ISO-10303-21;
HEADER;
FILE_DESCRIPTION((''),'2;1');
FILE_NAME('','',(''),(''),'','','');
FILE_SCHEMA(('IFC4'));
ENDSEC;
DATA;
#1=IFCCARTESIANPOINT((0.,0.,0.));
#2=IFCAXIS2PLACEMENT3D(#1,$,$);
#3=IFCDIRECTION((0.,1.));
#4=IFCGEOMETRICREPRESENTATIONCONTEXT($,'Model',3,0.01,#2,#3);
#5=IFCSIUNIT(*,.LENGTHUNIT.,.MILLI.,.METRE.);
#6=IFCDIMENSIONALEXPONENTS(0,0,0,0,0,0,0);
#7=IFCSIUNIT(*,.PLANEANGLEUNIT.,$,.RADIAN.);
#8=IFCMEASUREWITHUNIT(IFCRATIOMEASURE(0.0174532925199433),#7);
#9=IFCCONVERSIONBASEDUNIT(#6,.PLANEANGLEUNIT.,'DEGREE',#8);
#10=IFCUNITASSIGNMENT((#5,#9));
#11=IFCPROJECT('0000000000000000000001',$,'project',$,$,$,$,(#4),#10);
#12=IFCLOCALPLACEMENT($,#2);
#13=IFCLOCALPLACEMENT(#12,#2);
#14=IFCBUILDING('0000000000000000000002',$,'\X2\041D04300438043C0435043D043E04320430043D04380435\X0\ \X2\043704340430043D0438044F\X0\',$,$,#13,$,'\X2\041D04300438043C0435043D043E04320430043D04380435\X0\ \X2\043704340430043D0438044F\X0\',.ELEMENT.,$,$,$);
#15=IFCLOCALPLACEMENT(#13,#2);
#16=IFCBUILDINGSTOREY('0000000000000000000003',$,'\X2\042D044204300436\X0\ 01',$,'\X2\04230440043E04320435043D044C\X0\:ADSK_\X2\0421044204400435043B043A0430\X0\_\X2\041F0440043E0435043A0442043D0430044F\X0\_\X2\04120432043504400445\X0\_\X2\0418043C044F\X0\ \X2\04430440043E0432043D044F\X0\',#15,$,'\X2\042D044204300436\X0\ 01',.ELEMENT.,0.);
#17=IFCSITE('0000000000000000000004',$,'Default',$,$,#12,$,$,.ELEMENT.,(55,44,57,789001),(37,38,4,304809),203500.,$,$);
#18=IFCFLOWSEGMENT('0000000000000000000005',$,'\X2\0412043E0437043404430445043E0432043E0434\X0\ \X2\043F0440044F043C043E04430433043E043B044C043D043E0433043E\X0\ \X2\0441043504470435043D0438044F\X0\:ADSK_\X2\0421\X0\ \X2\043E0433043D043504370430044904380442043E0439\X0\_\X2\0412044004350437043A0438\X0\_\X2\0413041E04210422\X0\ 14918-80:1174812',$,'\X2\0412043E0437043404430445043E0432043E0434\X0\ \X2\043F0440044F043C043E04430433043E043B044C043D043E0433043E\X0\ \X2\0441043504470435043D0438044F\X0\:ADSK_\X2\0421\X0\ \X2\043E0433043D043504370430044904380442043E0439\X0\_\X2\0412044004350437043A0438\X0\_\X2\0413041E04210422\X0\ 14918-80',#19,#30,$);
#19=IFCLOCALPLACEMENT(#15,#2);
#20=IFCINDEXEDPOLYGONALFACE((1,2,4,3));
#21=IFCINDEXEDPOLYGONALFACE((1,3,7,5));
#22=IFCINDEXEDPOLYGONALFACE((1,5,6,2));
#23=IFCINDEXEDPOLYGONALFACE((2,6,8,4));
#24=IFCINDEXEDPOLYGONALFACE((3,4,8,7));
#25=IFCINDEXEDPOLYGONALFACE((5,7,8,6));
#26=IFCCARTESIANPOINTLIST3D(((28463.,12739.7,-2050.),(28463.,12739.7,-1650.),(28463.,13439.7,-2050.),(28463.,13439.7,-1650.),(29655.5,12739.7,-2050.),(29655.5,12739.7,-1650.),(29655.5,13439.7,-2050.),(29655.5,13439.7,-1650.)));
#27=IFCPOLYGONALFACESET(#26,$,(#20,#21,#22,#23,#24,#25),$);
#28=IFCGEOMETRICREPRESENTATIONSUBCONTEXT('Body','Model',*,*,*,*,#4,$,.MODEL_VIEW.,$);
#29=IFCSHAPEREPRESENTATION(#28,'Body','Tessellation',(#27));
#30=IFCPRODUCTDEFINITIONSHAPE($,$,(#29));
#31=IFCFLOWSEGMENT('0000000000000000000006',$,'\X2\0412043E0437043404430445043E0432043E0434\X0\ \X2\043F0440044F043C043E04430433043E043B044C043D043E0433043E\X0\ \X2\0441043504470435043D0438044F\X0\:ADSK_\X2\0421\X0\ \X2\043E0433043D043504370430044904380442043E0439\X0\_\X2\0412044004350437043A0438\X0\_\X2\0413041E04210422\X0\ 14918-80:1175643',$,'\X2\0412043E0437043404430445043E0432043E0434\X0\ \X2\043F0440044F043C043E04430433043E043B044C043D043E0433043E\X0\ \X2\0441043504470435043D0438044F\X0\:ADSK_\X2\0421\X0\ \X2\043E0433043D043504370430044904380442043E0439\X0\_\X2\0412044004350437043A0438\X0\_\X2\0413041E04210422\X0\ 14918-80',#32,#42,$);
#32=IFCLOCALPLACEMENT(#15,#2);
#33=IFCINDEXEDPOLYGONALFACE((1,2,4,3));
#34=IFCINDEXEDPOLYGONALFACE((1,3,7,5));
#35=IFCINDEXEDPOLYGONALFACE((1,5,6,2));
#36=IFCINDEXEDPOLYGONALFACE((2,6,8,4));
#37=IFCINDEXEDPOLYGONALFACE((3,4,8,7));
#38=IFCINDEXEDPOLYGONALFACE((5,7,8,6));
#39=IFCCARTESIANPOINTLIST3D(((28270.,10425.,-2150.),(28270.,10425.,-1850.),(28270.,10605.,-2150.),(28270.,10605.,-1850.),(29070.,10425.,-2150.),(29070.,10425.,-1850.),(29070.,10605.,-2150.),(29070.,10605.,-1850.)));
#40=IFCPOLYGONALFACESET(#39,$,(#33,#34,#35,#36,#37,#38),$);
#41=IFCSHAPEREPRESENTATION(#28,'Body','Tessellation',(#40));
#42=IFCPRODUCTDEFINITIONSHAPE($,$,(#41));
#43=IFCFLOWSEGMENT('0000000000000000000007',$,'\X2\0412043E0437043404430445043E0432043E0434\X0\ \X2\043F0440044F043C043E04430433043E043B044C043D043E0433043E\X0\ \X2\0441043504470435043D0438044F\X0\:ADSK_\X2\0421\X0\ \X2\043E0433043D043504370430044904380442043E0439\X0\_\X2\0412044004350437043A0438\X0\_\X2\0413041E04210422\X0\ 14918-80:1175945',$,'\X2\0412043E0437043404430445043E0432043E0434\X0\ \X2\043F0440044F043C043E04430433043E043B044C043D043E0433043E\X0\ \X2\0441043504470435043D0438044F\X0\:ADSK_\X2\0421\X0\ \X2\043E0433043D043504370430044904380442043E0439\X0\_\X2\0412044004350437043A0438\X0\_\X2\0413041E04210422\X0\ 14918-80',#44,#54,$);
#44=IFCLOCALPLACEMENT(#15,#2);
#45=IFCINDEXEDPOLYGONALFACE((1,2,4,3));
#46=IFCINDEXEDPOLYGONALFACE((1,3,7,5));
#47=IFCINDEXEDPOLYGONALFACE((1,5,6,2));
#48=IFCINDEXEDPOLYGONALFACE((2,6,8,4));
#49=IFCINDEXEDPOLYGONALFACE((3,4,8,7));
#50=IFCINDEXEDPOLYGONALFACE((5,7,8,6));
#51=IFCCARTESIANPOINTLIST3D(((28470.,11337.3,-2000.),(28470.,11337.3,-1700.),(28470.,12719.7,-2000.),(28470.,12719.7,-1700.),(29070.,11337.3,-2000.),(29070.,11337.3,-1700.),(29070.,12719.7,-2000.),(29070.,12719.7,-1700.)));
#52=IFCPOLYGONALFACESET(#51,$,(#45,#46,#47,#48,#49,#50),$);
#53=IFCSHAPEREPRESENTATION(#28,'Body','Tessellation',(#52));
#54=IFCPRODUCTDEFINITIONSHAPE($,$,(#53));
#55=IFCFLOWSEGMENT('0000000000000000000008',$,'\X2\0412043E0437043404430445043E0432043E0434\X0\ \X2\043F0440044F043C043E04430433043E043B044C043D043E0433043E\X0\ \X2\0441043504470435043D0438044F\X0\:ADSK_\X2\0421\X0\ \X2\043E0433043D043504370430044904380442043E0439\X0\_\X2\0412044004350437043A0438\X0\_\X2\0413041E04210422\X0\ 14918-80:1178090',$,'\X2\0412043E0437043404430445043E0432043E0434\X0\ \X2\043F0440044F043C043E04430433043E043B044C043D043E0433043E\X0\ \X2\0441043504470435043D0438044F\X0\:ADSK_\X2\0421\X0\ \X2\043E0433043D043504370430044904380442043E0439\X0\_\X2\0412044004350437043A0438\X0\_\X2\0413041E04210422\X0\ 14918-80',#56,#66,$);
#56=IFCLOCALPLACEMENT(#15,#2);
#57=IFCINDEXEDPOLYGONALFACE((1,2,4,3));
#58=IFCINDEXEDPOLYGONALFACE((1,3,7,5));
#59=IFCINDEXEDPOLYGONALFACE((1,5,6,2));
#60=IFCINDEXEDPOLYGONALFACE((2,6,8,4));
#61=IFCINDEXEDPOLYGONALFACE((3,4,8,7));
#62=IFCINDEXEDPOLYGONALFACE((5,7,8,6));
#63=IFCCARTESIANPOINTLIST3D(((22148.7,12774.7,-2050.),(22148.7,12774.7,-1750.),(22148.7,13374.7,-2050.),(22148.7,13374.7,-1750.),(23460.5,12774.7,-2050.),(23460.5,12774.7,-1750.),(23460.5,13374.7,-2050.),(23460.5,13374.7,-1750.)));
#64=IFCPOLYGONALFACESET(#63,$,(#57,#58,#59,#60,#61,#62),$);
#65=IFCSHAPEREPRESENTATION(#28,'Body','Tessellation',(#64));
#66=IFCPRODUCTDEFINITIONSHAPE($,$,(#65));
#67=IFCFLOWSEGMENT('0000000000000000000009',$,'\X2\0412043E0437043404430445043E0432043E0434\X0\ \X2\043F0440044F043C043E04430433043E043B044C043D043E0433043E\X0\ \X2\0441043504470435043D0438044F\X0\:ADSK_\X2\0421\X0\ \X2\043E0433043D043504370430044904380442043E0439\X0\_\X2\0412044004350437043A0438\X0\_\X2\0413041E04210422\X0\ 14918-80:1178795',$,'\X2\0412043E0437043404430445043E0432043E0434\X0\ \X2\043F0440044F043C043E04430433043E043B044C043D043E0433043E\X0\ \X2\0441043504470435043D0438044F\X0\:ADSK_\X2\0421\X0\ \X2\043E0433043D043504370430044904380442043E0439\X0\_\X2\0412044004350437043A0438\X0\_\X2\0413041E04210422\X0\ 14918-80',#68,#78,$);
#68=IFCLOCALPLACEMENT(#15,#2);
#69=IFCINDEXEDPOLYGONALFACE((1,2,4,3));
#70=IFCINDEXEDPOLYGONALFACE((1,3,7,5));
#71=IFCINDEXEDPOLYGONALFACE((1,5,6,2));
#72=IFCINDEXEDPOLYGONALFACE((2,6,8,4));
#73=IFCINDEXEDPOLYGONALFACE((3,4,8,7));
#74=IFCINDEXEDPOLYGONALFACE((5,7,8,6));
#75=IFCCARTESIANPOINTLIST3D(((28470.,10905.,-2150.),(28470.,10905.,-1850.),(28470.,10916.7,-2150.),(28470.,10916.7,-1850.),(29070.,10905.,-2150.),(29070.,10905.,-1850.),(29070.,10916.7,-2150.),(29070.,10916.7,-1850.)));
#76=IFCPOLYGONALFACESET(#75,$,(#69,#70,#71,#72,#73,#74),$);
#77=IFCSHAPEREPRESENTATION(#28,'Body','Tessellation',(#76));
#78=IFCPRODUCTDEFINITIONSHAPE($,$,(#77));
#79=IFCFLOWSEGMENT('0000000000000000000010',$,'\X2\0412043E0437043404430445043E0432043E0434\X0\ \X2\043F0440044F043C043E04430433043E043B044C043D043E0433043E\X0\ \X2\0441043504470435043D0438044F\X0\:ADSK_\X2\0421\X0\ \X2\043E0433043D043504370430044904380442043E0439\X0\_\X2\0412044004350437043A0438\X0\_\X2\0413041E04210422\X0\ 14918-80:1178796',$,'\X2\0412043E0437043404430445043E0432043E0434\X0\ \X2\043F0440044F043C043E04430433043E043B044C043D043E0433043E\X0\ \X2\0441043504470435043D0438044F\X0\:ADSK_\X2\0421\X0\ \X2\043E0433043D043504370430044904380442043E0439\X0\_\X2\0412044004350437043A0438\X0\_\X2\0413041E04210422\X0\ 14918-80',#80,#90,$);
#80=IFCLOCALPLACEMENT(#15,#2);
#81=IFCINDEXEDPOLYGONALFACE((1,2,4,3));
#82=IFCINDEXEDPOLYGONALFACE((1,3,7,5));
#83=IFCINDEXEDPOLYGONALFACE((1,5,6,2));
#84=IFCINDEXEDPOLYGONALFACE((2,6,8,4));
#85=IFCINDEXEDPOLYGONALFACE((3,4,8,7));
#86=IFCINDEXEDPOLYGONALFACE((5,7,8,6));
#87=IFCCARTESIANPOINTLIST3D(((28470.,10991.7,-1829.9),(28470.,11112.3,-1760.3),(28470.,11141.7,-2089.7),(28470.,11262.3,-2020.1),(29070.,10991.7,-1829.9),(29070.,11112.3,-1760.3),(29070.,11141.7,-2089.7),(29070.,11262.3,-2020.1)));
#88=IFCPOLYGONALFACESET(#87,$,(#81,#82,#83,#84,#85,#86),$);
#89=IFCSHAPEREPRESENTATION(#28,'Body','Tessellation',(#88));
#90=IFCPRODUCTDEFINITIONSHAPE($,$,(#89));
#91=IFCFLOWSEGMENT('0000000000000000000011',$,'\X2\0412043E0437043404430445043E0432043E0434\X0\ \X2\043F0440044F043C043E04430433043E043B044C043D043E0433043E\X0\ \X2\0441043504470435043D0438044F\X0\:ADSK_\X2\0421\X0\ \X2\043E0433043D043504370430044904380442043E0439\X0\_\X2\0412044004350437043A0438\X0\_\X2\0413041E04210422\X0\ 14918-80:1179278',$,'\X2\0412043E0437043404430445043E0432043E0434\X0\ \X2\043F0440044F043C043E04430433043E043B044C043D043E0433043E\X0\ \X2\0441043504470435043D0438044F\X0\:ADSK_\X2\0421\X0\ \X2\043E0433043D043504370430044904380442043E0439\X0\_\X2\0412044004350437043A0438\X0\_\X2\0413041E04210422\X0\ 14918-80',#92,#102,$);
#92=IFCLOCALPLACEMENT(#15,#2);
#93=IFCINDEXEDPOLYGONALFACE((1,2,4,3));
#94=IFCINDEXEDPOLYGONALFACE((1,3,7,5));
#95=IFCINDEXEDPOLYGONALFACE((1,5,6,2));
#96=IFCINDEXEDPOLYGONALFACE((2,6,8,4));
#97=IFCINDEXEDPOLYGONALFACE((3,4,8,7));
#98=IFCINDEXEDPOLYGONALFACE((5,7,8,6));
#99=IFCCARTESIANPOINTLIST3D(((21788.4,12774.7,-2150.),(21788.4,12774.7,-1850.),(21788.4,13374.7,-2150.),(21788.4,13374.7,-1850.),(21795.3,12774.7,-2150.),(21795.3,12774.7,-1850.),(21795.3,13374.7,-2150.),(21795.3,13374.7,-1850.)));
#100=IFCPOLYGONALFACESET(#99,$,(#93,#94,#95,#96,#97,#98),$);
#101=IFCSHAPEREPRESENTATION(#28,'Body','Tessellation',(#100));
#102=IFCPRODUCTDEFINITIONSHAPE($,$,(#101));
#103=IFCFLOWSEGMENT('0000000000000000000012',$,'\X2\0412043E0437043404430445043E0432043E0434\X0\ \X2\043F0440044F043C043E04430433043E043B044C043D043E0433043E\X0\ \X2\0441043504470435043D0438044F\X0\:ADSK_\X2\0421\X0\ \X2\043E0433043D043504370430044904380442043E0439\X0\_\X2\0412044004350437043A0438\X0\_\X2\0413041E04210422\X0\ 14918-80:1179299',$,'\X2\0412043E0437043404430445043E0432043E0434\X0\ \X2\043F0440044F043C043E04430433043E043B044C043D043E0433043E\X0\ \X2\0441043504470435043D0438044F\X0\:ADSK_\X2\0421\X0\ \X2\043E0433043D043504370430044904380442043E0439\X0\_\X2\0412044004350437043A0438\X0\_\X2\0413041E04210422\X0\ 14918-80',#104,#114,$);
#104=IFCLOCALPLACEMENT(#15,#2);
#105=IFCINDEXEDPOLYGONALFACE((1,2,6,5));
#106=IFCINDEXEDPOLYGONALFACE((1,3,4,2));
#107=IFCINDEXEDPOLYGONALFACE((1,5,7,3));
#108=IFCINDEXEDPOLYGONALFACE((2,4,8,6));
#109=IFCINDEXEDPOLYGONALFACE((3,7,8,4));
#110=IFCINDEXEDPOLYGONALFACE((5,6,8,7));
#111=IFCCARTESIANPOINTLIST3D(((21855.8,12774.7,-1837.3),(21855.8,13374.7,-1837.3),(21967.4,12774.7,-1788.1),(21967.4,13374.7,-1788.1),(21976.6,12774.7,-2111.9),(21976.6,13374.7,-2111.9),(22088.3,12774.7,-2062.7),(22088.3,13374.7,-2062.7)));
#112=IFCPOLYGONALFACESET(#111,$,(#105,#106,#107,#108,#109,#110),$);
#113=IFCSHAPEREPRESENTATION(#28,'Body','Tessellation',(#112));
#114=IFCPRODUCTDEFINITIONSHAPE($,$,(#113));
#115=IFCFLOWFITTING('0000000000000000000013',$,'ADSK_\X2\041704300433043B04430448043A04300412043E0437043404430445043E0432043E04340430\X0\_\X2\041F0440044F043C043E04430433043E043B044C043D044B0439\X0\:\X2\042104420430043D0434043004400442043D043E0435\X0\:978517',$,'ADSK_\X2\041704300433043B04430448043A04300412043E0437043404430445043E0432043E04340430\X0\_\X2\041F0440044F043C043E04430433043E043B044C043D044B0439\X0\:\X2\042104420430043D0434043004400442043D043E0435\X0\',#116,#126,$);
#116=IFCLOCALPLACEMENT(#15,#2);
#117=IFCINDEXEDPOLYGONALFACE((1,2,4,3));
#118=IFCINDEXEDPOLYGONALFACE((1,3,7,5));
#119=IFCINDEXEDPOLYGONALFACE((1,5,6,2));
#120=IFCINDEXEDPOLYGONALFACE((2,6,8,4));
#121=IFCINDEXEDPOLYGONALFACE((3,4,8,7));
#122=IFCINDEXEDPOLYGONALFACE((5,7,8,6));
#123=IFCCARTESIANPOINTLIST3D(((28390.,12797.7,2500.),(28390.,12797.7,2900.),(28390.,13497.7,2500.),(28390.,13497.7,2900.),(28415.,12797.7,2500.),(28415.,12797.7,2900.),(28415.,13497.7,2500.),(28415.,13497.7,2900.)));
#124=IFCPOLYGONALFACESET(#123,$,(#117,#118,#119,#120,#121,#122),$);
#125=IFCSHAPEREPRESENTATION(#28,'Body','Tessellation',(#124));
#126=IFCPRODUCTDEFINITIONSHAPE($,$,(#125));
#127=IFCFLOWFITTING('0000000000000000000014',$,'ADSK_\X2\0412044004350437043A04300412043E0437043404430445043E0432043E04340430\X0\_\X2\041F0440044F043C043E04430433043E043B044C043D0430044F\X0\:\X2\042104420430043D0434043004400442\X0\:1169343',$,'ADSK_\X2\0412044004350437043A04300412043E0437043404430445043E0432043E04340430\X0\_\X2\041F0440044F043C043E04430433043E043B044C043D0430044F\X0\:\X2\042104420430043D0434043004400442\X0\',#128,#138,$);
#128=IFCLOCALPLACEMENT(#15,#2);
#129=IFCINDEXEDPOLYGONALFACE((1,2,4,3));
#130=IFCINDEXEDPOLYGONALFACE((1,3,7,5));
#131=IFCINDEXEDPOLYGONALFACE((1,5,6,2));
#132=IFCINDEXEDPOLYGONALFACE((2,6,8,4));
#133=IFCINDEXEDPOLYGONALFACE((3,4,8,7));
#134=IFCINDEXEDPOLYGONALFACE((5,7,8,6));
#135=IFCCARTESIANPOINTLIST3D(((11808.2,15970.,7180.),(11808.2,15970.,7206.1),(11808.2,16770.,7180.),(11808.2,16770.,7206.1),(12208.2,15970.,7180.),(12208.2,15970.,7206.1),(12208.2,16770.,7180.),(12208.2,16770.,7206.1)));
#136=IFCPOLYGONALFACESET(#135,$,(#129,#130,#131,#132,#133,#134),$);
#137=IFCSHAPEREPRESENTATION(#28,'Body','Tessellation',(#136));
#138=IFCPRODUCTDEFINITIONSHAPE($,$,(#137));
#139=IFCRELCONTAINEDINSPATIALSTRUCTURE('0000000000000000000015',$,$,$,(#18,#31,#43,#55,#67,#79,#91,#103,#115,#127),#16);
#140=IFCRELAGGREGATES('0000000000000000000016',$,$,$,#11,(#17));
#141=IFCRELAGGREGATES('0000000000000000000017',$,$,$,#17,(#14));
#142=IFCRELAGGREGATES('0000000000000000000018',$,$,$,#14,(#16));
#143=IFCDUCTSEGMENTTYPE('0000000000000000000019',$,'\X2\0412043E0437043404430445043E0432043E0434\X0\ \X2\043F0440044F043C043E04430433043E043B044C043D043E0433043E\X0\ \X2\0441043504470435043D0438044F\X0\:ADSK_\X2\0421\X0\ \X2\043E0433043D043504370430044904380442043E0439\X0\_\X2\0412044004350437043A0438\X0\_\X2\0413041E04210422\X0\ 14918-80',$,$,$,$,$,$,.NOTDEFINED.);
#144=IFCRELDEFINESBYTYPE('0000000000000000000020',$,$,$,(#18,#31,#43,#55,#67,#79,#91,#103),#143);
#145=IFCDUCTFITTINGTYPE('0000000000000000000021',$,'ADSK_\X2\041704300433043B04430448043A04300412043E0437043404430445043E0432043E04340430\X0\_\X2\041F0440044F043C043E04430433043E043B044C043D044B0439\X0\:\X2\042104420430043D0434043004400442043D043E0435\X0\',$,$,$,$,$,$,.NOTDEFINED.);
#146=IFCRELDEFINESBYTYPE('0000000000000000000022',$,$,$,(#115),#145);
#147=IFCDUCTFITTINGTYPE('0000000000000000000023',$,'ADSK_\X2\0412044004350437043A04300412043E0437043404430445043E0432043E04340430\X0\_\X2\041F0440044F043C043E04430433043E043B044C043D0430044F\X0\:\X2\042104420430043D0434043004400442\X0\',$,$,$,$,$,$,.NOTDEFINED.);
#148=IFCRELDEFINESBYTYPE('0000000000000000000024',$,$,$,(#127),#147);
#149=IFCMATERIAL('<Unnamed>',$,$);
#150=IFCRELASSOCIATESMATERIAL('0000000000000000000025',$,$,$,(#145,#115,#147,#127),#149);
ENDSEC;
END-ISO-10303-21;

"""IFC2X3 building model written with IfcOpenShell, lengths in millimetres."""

from ifc_helpers import new_model, entity, si_unit, converted_unit, direction, frame, frame_2d, origin, origin_2d_with_axis, place, context, subcontext, project, spatial, rectangle, extrude, source, transform, mapped, material, type_object, type_shapes, element, save


model = new_model("IFC2X3")

# Units and contexts
model_context = context("Model", 3, precision=0.01, world=origin(), true_north=direction((0.0, 1.0)))
body_context = subcontext(model_context, "Body", "Model", "MODEL_VIEW")
ifc_project = project(units=[si_unit("LENGTHUNIT", "METRE", prefix="MILLI"), converted_unit("PLANEANGLEUNIT", "DEGREE", entity("IfcRatioMeasure", 0.0174532925199433), si_unit("PLANEANGLEUNIT", "RADIAN"), dimensions=[0, 0, 0, 0, 0, 0, 0])], contexts=[model_context])

# Site, building, storey
site_placement = place(None, origin())
site = spatial("IfcSite", under=ifc_project, at=site_placement, Name="Default", CompositionType="ELEMENT", RefLatitude=(55, 44, 57, 789001), RefLongitude=(37, 38, 4, 304809), RefElevation=203500.0)
building_placement = place(site_placement, origin())
building = spatial("IfcBuilding", under=site, at=building_placement, Name="Наименование здания", LongName="Наименование здания", CompositionType="ELEMENT")
storey_placement = place(building_placement, origin())
storey = spatial("IfcBuildingStorey", under=building, at=storey_placement, Name="Этаж 01", ObjectType="Уровень:ADSK_Стрелка_Проектная_Вверх_Имя уровня", LongName="Этаж 01", CompositionType="ELEMENT", Elevation=0.0)

# Flow segments
duct_segment_type = type_object("IfcDuctSegmentType", Name="Воздуховод прямоугольного сечения:ADSK_С огнезащитой_Врезки_ГОСТ 14918-80", PredefinedType="NOTDEFINED")
flow_segment_1_placement = place(storey_placement, frame((28463.0, 12739.7, -2050.0)))
element("IfcFlowSegment", 1, at=flow_segment_1_placement, inside=storey, type_object=duct_segment_type, Name="Воздуховод прямоугольного сечения:ADSK_С огнезащитой_Врезки_ГОСТ 14918-80:1174812", ObjectType="Воздуховод прямоугольного сечения:ADSK_С огнезащитой_Врезки_ГОСТ 14918-80", context=body_context, shape_type="SweptSolid", body=[
    extrude(rectangle(XDim=1192.5, YDim=700.0, at=origin_2d_with_axis()), frame((596.3, 350.0, 0.0), z_axis=(0.0, 0.0, 1.0), x_axis=(-1.0, 0.0, 0.0)), (0.0, 0.0, 1.0), 400.0),
])
flow_segment_2_placement = place(storey_placement, frame((28270.0, 10425.0, -2150.0)))
element("IfcFlowSegment", 2, at=flow_segment_2_placement, inside=storey, type_object=duct_segment_type, Name="Воздуховод прямоугольного сечения:ADSK_С огнезащитой_Врезки_ГОСТ 14918-80:1175643", ObjectType="Воздуховод прямоугольного сечения:ADSK_С огнезащитой_Врезки_ГОСТ 14918-80", context=body_context, shape_type="SweptSolid", body=[
    extrude(rectangle(XDim=180.0, YDim=800.0, at=origin_2d_with_axis()), frame((400.0, 90.0, 0.0), z_axis=(0.0, 0.0, 1.0), x_axis=(0.0, -1.0, 0.0)), (0.0, 0.0, 1.0), 300.0),
])
flow_segment_3_placement = place(storey_placement, frame((28470.0, 11337.3, -2000.0)))
element("IfcFlowSegment", 3, at=flow_segment_3_placement, inside=storey, type_object=duct_segment_type, Name="Воздуховод прямоугольного сечения:ADSK_С огнезащитой_Врезки_ГОСТ 14918-80:1175945", ObjectType="Воздуховод прямоугольного сечения:ADSK_С огнезащитой_Врезки_ГОСТ 14918-80", context=body_context, shape_type="SweptSolid", body=[
    extrude(rectangle(XDim=1382.4, YDim=600.0, at=origin_2d_with_axis()), frame((300.0, 691.2, 0.0), z_axis=(0.0, 0.0, 1.0), x_axis=(0.0, -1.0, 0.0)), (0.0, 0.0, 1.0), 300.0),
])
flow_segment_4_placement = place(storey_placement, frame((22148.7, 12774.7, -2050.0)))
element("IfcFlowSegment", 4, at=flow_segment_4_placement, inside=storey, type_object=duct_segment_type, Name="Воздуховод прямоугольного сечения:ADSK_С огнезащитой_Врезки_ГОСТ 14918-80:1178090", ObjectType="Воздуховод прямоугольного сечения:ADSK_С огнезащитой_Врезки_ГОСТ 14918-80", context=body_context, shape_type="SweptSolid", body=[
    extrude(rectangle(XDim=1311.8, YDim=600.0, at=origin_2d_with_axis()), frame((655.9, 300.0, 0.0)), (0.0, 0.0, 1.0), 300.0),
])
flow_segment_5_placement = place(storey_placement, frame((28470.0, 10905.0, -2150.0)))
element("IfcFlowSegment", 5, at=flow_segment_5_placement, inside=storey, type_object=duct_segment_type, Name="Воздуховод прямоугольного сечения:ADSK_С огнезащитой_Врезки_ГОСТ 14918-80:1178795", ObjectType="Воздуховод прямоугольного сечения:ADSK_С огнезащитой_Врезки_ГОСТ 14918-80", context=body_context, shape_type="SweptSolid", body=[
    extrude(rectangle(XDim=11.7, YDim=600.0, at=origin_2d_with_axis()), frame((300.0, 5.9, 0.0), z_axis=(0.0, 0.0, 1.0), x_axis=(0.0, 1.0, 0.0)), (0.0, 0.0, 1.0), 300.0),
])
flow_segment_6_placement = place(storey_placement, frame((28470.0, 10991.7, -2089.7)))
element("IfcFlowSegment", 6, at=flow_segment_6_placement, inside=storey, type_object=duct_segment_type, Name="Воздуховод прямоугольного сечения:ADSK_С огнезащитой_Врезки_ГОСТ 14918-80:1178796", ObjectType="Воздуховод прямоугольного сечения:ADSK_С огнезащитой_Врезки_ГОСТ 14918-80", context=body_context, shape_type="SweptSolid", body=[
    extrude(rectangle(XDim=300.0, YDim=139.2, at=frame_2d((0.0, 0.0), x_axis=(0.0, 1.0))), frame((0.0, 135.3, 164.7), z_axis=(1.0, 0.0, 0.0), x_axis=(0.0, 0.866025, 0.5)), (0.0, 0.0, 1.0), 600.0),
])
flow_segment_7_placement = place(storey_placement, frame((21788.4, 12774.7, -2150.0)))
element("IfcFlowSegment", 7, at=flow_segment_7_placement, inside=storey, type_object=duct_segment_type, Name="Воздуховод прямоугольного сечения:ADSK_С огнезащитой_Врезки_ГОСТ 14918-80:1179278", ObjectType="Воздуховод прямоугольного сечения:ADSK_С огнезащитой_Врезки_ГОСТ 14918-80", context=body_context, shape_type="SweptSolid", body=[
    extrude(rectangle(XDim=6.9, YDim=600.0, at=origin_2d_with_axis()), frame((3.4, 300.0, 0.0)), (0.0, 0.0, 1.0), 300.0),
])
flow_segment_8_placement = place(storey_placement, frame((21855.8, 12774.7, -2111.8)))
element("IfcFlowSegment", 8, at=flow_segment_8_placement, inside=storey, type_object=duct_segment_type, Name="Воздуховод прямоугольного сечения:ADSK_С огнезащитой_Врезки_ГОСТ 14918-80:1179299", ObjectType="Воздуховод прямоугольного сечения:ADSK_С огнезащитой_Врезки_ГОСТ 14918-80", context=body_context, shape_type="SweptSolid", body=[
    extrude(rectangle(XDim=300.0, YDim=122.0, at=frame_2d((0.0, 0.0), x_axis=(0.0, 1.0))), frame((116.2, 0.0, 161.8), z_axis=(0.0, 1.0, 0.0), x_axis=(-0.915232, 0.0, -0.402928)), (0.0, 0.0, 1.0), 600.0),
])

# Flow fittings
ifc_material = material(Name="<Unnamed>")
duct_fitting_type_1 = type_object("IfcDuctFittingType", Name="ADSK_ЗаглушкаВоздуховода_Прямоугольный:Стандартное", PredefinedType="NOTDEFINED", material=ifc_material)
shared_shape_1 = source(origin(), body_context, "Body", "SweptSolid", [
    extrude(rectangle(XDim=25.0, YDim=700.0, at=origin_2d_with_axis()), frame((12.5, 0.0, -200.0)), (0.0, 0.0, 1.0), 400.0),
])
type_shapes(duct_fitting_type_1, [shared_shape_1])
flow_fitting_1_placement = place(storey_placement, frame((28415.0, 13147.7, 2700.0), z_axis=(0.0, 0.0, 1.0), x_axis=(-1.0, 0.0, 0.0)))
element("IfcFlowFitting", 9, at=flow_fitting_1_placement, inside=storey, type_object=duct_fitting_type_1, material=ifc_material, Name="ADSK_ЗаглушкаВоздуховода_Прямоугольный:Стандартное:978517", ObjectType="ADSK_ЗаглушкаВоздуховода_Прямоугольный:Стандартное", context=body_context, shape_type="MappedRepresentation", body=[
    mapped(shared_shape_1, transform((0.0, 0.0, 0.0), scale=1.0)),
])
duct_fitting_type_2 = type_object("IfcDuctFittingType", Name="ADSK_ВрезкаВоздуховода_Прямоугольная:Стандарт", PredefinedType="NOTDEFINED", material=ifc_material)
shared_shape_2 = source(origin(), body_context, "Body", "SweptSolid", [
    extrude(rectangle(XDim=400.0, YDim=26.1, at=origin_2d_with_axis()), frame((7.0, 0.0, -400.0), z_axis=(0.0, 0.0, 1.0), x_axis=(0.0, -1.0, 0.0)), (0.0, 0.0, 1.0), 800.0),
])
type_shapes(duct_fitting_type_2, [shared_shape_2])
flow_fitting_2_placement = place(storey_placement, frame((12008.2, 16370.0, 7200.0), z_axis=(0.0, 1.0, 0.0), x_axis=(0.0, 0.0, -1.0)))
element("IfcFlowFitting", 10, at=flow_fitting_2_placement, inside=storey, type_object=duct_fitting_type_2, material=ifc_material, Name="ADSK_ВрезкаВоздуховода_Прямоугольная:Стандарт:1169343", ObjectType="ADSK_ВрезкаВоздуховода_Прямоугольная:Стандарт", context=body_context, shape_type="MappedRepresentation", body=[
    mapped(shared_shape_2, transform((0.0, 0.0, 0.0), scale=1.0)),
])

save(model, "model.ifc")
